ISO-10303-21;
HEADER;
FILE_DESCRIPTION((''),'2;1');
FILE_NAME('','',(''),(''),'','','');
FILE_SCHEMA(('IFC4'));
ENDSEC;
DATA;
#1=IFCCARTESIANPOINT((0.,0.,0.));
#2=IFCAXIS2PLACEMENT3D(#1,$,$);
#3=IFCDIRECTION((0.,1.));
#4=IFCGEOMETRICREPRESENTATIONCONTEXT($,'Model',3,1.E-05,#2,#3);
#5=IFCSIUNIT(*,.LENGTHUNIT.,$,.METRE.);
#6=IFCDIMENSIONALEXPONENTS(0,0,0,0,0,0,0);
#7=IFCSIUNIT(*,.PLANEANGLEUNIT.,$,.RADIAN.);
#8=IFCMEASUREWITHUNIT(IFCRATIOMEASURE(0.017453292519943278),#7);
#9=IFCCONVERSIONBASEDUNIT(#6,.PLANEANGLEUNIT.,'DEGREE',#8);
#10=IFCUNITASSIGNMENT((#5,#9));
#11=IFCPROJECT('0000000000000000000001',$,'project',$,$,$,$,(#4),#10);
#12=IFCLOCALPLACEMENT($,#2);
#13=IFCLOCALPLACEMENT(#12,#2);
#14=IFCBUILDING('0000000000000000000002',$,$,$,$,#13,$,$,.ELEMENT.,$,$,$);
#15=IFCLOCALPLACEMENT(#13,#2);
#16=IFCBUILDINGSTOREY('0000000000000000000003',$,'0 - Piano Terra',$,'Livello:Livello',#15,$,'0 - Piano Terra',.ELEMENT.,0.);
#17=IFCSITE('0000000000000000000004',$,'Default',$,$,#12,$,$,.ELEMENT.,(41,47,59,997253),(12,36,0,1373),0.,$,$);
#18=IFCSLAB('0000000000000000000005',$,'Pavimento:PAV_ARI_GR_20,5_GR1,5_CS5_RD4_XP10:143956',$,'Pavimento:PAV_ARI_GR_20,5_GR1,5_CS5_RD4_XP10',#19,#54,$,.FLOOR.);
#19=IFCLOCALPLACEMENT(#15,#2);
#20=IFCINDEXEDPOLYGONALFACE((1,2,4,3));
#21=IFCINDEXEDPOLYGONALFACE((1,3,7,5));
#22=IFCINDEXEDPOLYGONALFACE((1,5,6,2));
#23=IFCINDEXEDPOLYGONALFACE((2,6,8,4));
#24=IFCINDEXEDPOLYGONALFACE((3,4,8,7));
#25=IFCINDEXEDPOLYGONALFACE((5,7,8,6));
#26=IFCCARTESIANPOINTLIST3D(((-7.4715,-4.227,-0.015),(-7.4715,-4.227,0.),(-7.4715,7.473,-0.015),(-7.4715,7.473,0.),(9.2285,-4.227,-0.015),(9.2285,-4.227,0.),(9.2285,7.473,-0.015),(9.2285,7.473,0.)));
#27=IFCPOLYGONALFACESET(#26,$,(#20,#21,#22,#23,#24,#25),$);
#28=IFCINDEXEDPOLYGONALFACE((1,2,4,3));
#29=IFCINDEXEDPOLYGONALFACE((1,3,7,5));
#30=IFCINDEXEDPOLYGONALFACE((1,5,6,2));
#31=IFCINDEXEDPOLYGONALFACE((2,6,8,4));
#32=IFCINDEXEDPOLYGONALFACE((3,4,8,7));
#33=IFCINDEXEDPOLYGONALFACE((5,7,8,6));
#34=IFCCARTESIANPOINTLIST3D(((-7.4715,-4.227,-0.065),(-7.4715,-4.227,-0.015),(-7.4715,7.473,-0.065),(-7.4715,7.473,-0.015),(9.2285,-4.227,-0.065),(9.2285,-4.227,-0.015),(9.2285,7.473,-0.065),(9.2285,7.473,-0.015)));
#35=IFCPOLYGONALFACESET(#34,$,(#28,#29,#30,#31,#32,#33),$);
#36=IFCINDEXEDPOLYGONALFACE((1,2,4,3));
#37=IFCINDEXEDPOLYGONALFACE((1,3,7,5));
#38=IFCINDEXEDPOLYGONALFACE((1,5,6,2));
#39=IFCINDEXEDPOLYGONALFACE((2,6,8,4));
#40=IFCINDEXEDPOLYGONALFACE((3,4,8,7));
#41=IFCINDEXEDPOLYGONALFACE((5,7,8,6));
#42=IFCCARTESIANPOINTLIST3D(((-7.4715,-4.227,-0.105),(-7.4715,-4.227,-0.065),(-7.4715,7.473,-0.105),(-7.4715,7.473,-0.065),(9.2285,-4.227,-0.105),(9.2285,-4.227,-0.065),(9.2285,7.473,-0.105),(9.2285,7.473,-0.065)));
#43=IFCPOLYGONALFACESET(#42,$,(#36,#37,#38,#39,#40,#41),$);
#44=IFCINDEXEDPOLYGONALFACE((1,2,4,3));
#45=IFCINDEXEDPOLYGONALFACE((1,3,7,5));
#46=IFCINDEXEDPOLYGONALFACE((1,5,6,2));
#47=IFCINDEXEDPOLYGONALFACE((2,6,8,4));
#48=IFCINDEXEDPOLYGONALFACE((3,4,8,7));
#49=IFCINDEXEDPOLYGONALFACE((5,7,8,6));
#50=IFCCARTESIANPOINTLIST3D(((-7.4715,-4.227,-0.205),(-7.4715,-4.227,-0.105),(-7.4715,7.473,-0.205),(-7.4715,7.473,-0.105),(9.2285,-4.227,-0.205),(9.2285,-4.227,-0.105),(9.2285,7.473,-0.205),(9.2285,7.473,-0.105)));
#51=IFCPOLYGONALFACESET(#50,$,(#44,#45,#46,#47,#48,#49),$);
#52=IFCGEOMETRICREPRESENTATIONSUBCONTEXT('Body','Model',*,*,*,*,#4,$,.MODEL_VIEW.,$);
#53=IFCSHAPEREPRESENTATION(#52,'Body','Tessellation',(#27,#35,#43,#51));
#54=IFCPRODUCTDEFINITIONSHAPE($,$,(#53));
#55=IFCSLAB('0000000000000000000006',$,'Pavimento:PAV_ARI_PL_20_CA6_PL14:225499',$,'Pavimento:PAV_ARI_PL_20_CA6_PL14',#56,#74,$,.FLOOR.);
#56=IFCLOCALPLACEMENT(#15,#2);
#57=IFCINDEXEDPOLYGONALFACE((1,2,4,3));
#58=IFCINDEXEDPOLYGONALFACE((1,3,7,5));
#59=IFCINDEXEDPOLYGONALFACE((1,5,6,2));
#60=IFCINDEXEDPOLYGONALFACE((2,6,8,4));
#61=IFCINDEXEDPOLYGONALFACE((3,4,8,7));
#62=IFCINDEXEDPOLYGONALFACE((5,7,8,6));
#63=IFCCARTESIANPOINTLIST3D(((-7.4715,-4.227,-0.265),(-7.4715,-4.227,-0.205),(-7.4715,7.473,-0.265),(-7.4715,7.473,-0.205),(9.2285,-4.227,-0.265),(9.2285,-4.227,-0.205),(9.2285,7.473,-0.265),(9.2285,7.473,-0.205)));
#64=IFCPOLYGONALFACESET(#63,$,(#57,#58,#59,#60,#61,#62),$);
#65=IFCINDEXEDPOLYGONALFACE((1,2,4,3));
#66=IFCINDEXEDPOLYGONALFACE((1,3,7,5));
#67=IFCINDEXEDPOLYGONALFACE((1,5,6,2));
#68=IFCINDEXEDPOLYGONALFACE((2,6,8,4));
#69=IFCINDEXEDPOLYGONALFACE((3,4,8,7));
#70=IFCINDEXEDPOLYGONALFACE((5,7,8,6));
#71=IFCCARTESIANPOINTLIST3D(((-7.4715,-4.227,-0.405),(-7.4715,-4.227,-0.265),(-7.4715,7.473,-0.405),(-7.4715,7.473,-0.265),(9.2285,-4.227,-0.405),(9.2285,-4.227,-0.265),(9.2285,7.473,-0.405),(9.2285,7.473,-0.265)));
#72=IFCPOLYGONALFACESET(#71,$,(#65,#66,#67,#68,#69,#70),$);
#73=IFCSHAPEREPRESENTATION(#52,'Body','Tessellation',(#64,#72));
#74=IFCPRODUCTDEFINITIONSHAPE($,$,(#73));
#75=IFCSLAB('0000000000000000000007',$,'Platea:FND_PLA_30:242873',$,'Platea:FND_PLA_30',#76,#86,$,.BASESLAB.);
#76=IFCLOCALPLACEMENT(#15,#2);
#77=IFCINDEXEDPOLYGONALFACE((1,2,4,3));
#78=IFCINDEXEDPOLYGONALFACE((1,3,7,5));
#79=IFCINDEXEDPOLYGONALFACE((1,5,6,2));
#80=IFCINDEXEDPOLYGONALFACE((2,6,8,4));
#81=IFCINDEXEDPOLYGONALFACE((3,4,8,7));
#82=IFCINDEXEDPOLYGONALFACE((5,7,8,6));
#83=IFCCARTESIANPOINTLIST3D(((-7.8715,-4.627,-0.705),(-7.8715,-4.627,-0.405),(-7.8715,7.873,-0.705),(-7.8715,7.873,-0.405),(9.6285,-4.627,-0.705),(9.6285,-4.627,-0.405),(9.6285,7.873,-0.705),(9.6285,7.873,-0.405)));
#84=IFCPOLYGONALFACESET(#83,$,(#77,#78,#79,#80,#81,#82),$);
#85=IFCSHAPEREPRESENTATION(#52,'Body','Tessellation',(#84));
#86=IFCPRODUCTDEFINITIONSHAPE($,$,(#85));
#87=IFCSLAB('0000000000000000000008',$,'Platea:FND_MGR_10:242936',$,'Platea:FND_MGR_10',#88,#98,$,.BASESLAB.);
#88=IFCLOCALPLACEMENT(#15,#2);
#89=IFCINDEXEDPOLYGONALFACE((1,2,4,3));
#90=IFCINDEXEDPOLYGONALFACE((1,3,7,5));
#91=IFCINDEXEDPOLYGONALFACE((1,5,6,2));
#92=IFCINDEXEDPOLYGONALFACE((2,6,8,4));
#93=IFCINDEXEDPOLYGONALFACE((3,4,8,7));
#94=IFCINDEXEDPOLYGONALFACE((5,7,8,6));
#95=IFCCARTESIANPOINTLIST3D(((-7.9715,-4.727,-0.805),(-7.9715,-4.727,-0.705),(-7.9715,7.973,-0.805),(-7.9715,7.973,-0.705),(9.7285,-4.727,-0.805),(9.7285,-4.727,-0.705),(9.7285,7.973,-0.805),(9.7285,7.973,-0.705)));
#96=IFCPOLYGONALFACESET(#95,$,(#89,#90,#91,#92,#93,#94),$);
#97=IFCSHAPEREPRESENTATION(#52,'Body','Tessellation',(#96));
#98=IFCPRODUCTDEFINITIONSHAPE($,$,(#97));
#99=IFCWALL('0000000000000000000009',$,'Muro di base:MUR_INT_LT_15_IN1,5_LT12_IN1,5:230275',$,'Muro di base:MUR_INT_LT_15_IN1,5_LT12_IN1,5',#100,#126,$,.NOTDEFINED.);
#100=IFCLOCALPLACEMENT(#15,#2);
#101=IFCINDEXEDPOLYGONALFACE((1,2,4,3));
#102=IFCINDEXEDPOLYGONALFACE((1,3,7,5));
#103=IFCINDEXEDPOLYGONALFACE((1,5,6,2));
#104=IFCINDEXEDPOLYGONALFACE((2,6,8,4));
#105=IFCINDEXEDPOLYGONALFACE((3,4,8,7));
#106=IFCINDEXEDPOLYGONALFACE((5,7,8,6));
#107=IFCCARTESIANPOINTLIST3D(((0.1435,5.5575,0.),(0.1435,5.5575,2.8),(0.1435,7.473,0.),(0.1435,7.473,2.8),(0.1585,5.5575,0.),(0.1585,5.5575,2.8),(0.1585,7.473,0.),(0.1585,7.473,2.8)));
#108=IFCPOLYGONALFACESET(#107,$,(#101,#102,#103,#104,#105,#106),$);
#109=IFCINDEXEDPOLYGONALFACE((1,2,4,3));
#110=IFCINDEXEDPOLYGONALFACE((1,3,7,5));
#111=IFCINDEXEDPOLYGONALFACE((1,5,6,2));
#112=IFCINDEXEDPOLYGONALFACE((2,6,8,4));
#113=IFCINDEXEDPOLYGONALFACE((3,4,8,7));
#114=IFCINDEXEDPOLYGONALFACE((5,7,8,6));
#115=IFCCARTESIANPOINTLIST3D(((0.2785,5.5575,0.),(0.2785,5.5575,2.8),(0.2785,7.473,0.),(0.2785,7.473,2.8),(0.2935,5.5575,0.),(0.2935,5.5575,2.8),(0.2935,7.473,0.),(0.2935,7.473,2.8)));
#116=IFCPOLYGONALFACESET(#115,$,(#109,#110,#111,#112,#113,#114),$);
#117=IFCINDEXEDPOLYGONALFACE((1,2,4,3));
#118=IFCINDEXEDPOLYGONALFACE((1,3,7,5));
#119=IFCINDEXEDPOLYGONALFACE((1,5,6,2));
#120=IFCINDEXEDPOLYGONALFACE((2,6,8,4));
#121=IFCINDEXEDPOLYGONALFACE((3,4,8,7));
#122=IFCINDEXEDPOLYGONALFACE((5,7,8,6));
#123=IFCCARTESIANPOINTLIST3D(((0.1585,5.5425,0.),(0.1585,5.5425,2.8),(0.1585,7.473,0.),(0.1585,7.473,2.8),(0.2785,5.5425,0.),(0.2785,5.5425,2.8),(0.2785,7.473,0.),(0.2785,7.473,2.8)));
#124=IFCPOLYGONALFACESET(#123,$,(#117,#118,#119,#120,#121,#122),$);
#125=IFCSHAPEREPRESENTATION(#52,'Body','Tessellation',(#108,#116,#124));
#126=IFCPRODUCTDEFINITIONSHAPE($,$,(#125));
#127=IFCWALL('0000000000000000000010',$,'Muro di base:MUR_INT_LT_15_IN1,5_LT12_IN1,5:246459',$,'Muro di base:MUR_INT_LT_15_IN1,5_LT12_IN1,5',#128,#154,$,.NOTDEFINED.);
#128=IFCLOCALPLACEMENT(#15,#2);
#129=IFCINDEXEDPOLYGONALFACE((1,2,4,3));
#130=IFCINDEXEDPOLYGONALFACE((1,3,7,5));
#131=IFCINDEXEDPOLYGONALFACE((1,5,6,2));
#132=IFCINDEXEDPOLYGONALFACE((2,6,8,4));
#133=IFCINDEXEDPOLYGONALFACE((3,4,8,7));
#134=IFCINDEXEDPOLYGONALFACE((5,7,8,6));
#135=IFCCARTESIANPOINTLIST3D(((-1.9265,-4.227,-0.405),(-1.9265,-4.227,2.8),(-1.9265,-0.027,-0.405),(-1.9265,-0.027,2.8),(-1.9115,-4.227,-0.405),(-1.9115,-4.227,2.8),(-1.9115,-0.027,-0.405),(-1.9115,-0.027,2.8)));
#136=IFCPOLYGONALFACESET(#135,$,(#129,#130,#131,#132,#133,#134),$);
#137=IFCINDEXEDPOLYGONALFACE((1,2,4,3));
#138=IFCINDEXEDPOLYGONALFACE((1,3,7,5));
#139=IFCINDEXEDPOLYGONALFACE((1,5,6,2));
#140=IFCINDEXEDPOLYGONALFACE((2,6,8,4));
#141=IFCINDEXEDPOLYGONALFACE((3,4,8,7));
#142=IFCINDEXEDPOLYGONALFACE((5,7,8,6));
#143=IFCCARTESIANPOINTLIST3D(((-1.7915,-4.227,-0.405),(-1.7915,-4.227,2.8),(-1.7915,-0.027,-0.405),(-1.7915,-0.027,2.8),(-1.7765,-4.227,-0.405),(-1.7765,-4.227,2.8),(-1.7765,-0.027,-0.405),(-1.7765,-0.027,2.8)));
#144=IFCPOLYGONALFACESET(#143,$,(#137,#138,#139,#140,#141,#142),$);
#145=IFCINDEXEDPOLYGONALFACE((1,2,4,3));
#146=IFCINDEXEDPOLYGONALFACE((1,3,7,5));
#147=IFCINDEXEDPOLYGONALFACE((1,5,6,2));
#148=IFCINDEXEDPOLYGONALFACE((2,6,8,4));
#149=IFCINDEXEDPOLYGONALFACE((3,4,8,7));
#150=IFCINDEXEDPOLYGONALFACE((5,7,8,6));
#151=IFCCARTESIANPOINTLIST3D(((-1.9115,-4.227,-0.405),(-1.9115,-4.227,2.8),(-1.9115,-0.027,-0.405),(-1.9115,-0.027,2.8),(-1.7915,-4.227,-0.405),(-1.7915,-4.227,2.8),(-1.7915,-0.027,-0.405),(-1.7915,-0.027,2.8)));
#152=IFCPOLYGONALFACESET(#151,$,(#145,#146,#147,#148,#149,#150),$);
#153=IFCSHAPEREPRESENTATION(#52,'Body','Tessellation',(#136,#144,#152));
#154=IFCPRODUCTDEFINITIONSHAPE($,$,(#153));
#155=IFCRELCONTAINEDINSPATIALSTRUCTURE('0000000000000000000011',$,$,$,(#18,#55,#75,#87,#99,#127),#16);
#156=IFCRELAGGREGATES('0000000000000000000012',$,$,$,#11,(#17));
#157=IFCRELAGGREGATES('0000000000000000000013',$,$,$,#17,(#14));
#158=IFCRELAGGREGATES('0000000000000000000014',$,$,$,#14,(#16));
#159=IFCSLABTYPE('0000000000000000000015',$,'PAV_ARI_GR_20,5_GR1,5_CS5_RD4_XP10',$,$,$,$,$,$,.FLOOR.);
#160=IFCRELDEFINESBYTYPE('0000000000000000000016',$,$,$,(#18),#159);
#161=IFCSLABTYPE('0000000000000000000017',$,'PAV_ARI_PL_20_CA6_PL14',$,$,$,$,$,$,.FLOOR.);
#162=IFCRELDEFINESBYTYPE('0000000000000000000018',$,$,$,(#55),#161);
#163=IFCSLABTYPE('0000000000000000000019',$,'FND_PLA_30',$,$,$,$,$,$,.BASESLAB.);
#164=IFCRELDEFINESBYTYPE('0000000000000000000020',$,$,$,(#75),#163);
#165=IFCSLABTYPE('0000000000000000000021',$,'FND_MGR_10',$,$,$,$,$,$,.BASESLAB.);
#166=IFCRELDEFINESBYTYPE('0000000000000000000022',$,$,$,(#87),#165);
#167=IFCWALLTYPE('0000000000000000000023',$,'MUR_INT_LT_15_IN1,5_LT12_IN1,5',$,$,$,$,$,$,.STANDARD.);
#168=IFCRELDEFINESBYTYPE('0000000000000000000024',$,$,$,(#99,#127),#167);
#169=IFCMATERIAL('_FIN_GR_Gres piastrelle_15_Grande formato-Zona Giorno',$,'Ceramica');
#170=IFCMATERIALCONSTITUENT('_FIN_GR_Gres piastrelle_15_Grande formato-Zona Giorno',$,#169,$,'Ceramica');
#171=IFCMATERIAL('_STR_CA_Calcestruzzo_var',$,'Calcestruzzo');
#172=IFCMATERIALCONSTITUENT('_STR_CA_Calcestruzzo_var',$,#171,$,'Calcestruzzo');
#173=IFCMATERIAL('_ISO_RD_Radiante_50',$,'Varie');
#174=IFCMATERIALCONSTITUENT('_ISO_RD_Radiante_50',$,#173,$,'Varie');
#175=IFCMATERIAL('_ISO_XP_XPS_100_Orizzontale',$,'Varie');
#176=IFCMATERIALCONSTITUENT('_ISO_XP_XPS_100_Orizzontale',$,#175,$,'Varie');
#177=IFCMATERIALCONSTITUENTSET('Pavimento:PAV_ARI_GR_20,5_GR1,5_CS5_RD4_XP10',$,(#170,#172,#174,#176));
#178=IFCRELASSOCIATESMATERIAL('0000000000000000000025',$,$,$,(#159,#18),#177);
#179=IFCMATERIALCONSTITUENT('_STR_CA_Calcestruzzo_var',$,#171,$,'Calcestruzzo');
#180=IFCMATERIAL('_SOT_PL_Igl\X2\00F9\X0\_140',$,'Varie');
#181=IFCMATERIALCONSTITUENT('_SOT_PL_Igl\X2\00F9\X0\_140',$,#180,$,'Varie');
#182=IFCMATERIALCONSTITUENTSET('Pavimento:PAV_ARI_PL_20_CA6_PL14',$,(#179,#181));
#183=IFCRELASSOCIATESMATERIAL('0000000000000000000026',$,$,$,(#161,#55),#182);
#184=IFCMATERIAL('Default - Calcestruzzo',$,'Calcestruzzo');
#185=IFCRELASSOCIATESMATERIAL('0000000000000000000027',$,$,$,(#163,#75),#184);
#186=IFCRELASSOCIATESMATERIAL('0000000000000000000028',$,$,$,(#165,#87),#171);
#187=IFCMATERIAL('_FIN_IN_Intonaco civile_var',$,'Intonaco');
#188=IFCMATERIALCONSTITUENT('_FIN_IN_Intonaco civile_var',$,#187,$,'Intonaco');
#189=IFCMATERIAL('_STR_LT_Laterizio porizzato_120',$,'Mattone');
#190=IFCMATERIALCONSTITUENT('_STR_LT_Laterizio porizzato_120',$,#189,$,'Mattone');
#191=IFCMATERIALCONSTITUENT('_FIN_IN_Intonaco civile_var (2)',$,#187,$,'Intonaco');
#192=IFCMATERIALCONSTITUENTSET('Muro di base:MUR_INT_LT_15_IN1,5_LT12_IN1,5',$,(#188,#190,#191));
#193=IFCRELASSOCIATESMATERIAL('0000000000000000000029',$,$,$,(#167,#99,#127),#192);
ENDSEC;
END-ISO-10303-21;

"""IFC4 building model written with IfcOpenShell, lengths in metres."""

from ifc_helpers import new_model, entity, si_unit, converted_unit, direction, frame, origin, place, context, subcontext, project, spatial, indexed_curve, outline, extrude, material, constituent, constituent_set, type_object, element, save


model = new_model("IFC4")

# Units and contexts
model_context = context("Model", 3, precision=1e-05, world=origin(), true_north=direction((0.0, 1.0)))
body_context = subcontext(model_context, "Body", "Model", "MODEL_VIEW")
ifc_project = project(units=[si_unit("LENGTHUNIT", "METRE"), converted_unit("PLANEANGLEUNIT", "DEGREE", entity("IfcRatioMeasure", 0.017453292519943278), si_unit("PLANEANGLEUNIT", "RADIAN"), dimensions=[0, 0, 0, 0, 0, 0, 0])], contexts=[model_context])

# Site, building, storey
site_placement = place(None, origin())
site = spatial("IfcSite", under=ifc_project, at=site_placement, Name="Default", CompositionType="ELEMENT", RefLatitude=(41, 47, 59, 997253), RefLongitude=(12, 36, 0, 1373), RefElevation=0.0)
building_placement = place(site_placement, origin())
building = spatial("IfcBuilding", under=site, at=building_placement, CompositionType="ELEMENT")
storey_placement = place(building_placement, origin())
storey = spatial("IfcBuildingStorey", under=building, at=storey_placement, Name="0 - Piano Terra", ObjectType="Livello:Livello", LongName="0 - Piano Terra", CompositionType="ELEMENT", Elevation=0.0)

# Slabs
ifc_material_1 = material(Name="_FIN_GR_Gres piastrelle_15_Grande formato-Zona Giorno", Category="Ceramica")
ifc_constituent_1 = constituent(ifc_material_1, Name="_FIN_GR_Gres piastrelle_15_Grande formato-Zona Giorno", Category="Ceramica")
ifc_material_2 = material(Name="_STR_CA_Calcestruzzo_var", Category="Calcestruzzo")
ifc_constituent_2 = constituent(ifc_material_2, Name="_STR_CA_Calcestruzzo_var", Category="Calcestruzzo")
ifc_material_3 = material(Name="_ISO_RD_Radiante_50", Category="Varie")
ifc_constituent_3 = constituent(ifc_material_3, Name="_ISO_RD_Radiante_50", Category="Varie")
ifc_material_4 = material(Name="_ISO_XP_XPS_100_Orizzontale", Category="Varie")
ifc_constituent_4 = constituent(ifc_material_4, Name="_ISO_XP_XPS_100_Orizzontale", Category="Varie")
ifc_constituent_set_1 = constituent_set(constituents=[ifc_constituent_1, ifc_constituent_2, ifc_constituent_3, ifc_constituent_4], Name="Pavimento:PAV_ARI_GR_20,5_GR1,5_CS5_RD4_XP10")
slab_type_1 = type_object("IfcSlabType", Name="PAV_ARI_GR_20,5_GR1,5_CS5_RD4_XP10", PredefinedType="FLOOR", material=ifc_constituent_set_1)
slab_1_placement = place(storey_placement, origin())
element("IfcSlab", 1, at=slab_1_placement, inside=storey, type_object=slab_type_1, material=ifc_constituent_set_1, Name="Pavimento:PAV_ARI_GR_20,5_GR1,5_CS5_RD4_XP10:143956", ObjectType="Pavimento:PAV_ARI_GR_20,5_GR1,5_CS5_RD4_XP10", PredefinedType="FLOOR", context=body_context, shape_type="SweptSolid", body=[
    extrude(outline(indexed_curve([(-8.35, -5.85), (8.35, -5.85), (8.35, 5.85), (-8.35, 5.85), (-8.35, -5.85)], self_intersect=False)), frame((0.8785, 1.623, -0.015), z_axis=(0.0, 0.0, 1.0), x_axis=(-1.0, 0.0, 0.0)), (0.0, 0.0, 1.0), 0.015),
    extrude(outline(indexed_curve([(-8.35, -5.85), (8.35, -5.85), (8.35, 5.85), (-8.35, 5.85), (-8.35, -5.85)], self_intersect=False)), frame((0.8785, 1.623, -0.065), z_axis=(0.0, 0.0, 1.0), x_axis=(-1.0, 0.0, 0.0)), (0.0, 0.0, 1.0), 0.05),
    extrude(outline(indexed_curve([(-8.35, -5.85), (8.35, -5.85), (8.35, 5.85), (-8.35, 5.85), (-8.35, -5.85)], self_intersect=False)), frame((0.8785, 1.623, -0.105), z_axis=(0.0, 0.0, 1.0), x_axis=(-1.0, 0.0, 0.0)), (0.0, 0.0, 1.0), 0.04),
    extrude(outline(indexed_curve([(-8.35, -5.85), (8.35, -5.85), (8.35, 5.85), (-8.35, 5.85), (-8.35, -5.85)], self_intersect=False)), frame((0.8785, 1.623, -0.205), z_axis=(0.0, 0.0, 1.0), x_axis=(-1.0, 0.0, 0.0)), (0.0, 0.0, 1.0), 0.1),
])
ifc_constituent_5 = constituent(ifc_material_2, Name="_STR_CA_Calcestruzzo_var", Category="Calcestruzzo")
ifc_material_5 = material(Name="_SOT_PL_Iglù_140", Category="Varie")
ifc_constituent_6 = constituent(ifc_material_5, Name="_SOT_PL_Iglù_140", Category="Varie")
ifc_constituent_set_2 = constituent_set(constituents=[ifc_constituent_5, ifc_constituent_6], Name="Pavimento:PAV_ARI_PL_20_CA6_PL14")
slab_type_2 = type_object("IfcSlabType", Name="PAV_ARI_PL_20_CA6_PL14", PredefinedType="FLOOR", material=ifc_constituent_set_2)
slab_2_placement = place(storey_placement, origin())
element("IfcSlab", 2, at=slab_2_placement, inside=storey, type_object=slab_type_2, material=ifc_constituent_set_2, Name="Pavimento:PAV_ARI_PL_20_CA6_PL14:225499", ObjectType="Pavimento:PAV_ARI_PL_20_CA6_PL14", PredefinedType="FLOOR", context=body_context, shape_type="SweptSolid", body=[
    extrude(outline(indexed_curve([(-8.35, -5.85), (8.35, -5.85), (8.35, 5.85), (-8.35, 5.85), (-8.35, -5.85)], self_intersect=False)), frame((0.8785, 1.623, -0.265), z_axis=(0.0, 0.0, 1.0), x_axis=(-1.0, 0.0, 0.0)), (0.0, 0.0, 1.0), 0.06),
    extrude(outline(indexed_curve([(-8.35, -5.85), (8.35, -5.85), (8.35, 5.85), (-8.35, 5.85), (-8.35, -5.85)], self_intersect=False)), frame((0.8785, 1.623, -0.405), z_axis=(0.0, 0.0, 1.0), x_axis=(-1.0, 0.0, 0.0)), (0.0, 0.0, 1.0), 0.14),
])
ifc_material_6 = material(Name="Default - Calcestruzzo", Category="Calcestruzzo")
slab_type_3 = type_object("IfcSlabType", Name="FND_PLA_30", PredefinedType="BASESLAB", material=ifc_material_6)
slab_3_placement = place(storey_placement, origin())
element("IfcSlab", 3, at=slab_3_placement, inside=storey, type_object=slab_type_3, material=ifc_material_6, Name="Platea:FND_PLA_30:242873", ObjectType="Platea:FND_PLA_30", PredefinedType="BASESLAB", context=body_context, shape_type="SweptSolid", body=[
    extrude(outline(indexed_curve([(-6.25, -8.75), (6.25, -8.75), (6.25, 8.75), (-6.25, 8.75), (-6.25, -8.75)], self_intersect=False)), frame((0.8785, 1.623, -0.405), z_axis=(0.0, 0.0, -1.0), x_axis=(0.0, 1.0, 0.0)), (0.0, 0.0, 1.0), 0.3),
])
slab_type_4 = type_object("IfcSlabType", Name="FND_MGR_10", PredefinedType="BASESLAB", material=ifc_material_2)
slab_4_placement = place(storey_placement, origin())
element("IfcSlab", 4, at=slab_4_placement, inside=storey, type_object=slab_type_4, material=ifc_material_2, Name="Platea:FND_MGR_10:242936", ObjectType="Platea:FND_MGR_10", PredefinedType="BASESLAB", context=body_context, shape_type="SweptSolid", body=[
    extrude(outline(indexed_curve([(-6.35, -8.85), (6.35, -8.85), (6.35, 8.85), (-6.35, 8.85), (-6.35, -8.85)], self_intersect=False)), frame((0.8785, 1.623, -0.705), z_axis=(0.0, 0.0, -1.0), x_axis=(0.0, 1.0, 0.0)), (0.0, 0.0, 1.0), 0.1),
])

# Walls
ifc_material_7 = material(Name="_FIN_IN_Intonaco civile_var", Category="Intonaco")
ifc_constituent_7 = constituent(ifc_material_7, Name="_FIN_IN_Intonaco civile_var", Category="Intonaco")
ifc_material_8 = material(Name="_STR_LT_Laterizio porizzato_120", Category="Mattone")
ifc_constituent_8 = constituent(ifc_material_8, Name="_STR_LT_Laterizio porizzato_120", Category="Mattone")
ifc_constituent_9 = constituent(ifc_material_7, Name="_FIN_IN_Intonaco civile_var (2)", Category="Intonaco")
ifc_constituent_set_3 = constituent_set(constituents=[ifc_constituent_7, ifc_constituent_8, ifc_constituent_9], Name="Muro di base:MUR_INT_LT_15_IN1,5_LT12_IN1,5")
wall_type = type_object("IfcWallType", Name="MUR_INT_LT_15_IN1,5_LT12_IN1,5", PredefinedType="STANDARD", material=ifc_constituent_set_3)
wall_1_placement = place(storey_placement, frame((0.2185, 5.5575, 0.0), z_axis=(0.0, 0.0, 1.0), x_axis=(0.0, 1.0, 0.0)))
element("IfcWall", 5, at=wall_1_placement, inside=storey, type_object=wall_type, material=ifc_constituent_set_3, Name="Muro di base:MUR_INT_LT_15_IN1,5_LT12_IN1,5:230275", ObjectType="Muro di base:MUR_INT_LT_15_IN1,5_LT12_IN1,5", PredefinedType="NOTDEFINED", context=body_context, shape_type="SweptSolid", body=[
    extrude(outline(indexed_curve([(-0.0075, -0.9577), (0.0075, -0.9577), (0.0075, 0.9577), (-0.0075, 0.9577), (-0.0075, -0.9577)], self_intersect=False)), frame((0.9577, 0.0675, 0.0), z_axis=(0.0, 0.0, 1.0), x_axis=(0.0, -1.0, 0.0)), (0.0, 0.0, 1.0), 2.8),
    extrude(outline(indexed_curve([(-0.0075, -0.9577), (0.0075, -0.9577), (0.0075, 0.9577), (-0.0075, 0.9577), (-0.0075, -0.9577)], self_intersect=False)), frame((0.9577, -0.0675, 0.0), z_axis=(0.0, 0.0, 1.0), x_axis=(0.0, 1.0, 0.0)), (0.0, 0.0, 1.0), 2.8),
    extrude(outline(indexed_curve([(-0.9652, -0.06), (0.9652, -0.06), (0.9652, 0.06), (-0.9652, 0.06), (-0.9652, -0.06)], self_intersect=False)), frame((0.9502, 0.0, 0.0)), (0.0, 0.0, 1.0), 2.8),
])
wall_2_placement = place(storey_placement, frame((-1.8515, -0.027, -0.405), z_axis=(0.0, 0.0, 1.0), x_axis=(0.0, -1.0, 0.0)))
element("IfcWall", 6, at=wall_2_placement, inside=storey, type_object=wall_type, material=ifc_constituent_set_3, Name="Muro di base:MUR_INT_LT_15_IN1,5_LT12_IN1,5:246459", ObjectType="Muro di base:MUR_INT_LT_15_IN1,5_LT12_IN1,5", PredefinedType="NOTDEFINED", context=body_context, shape_type="SweptSolid", body=[
    extrude(outline(indexed_curve([(-0.0075, -2.1), (0.0075, -2.1), (0.0075, 2.1), (-0.0075, 2.1), (-0.0075, -2.1)], self_intersect=False)), frame((2.1, -0.0675, 0.0), z_axis=(0.0, 0.0, 1.0), x_axis=(0.0, 1.0, 0.0)), (0.0, 0.0, 1.0), 3.205),
    extrude(outline(indexed_curve([(-0.0075, -2.1), (0.0075, -2.1), (0.0075, 2.1), (-0.0075, 2.1), (-0.0075, -2.1)], self_intersect=False)), frame((2.1, 0.0675, 0.0), z_axis=(0.0, 0.0, 1.0), x_axis=(0.0, -1.0, 0.0)), (0.0, 0.0, 1.0), 3.205),
    extrude(outline(indexed_curve([(-2.1, -0.06), (2.1, -0.06), (2.1, 0.06), (-2.1, 0.06), (-2.1, -0.06)], self_intersect=False)), frame((2.1, 0.0, 0.0)), (0.0, 0.0, 1.0), 3.205),
])

save(model, "model.ifc")
